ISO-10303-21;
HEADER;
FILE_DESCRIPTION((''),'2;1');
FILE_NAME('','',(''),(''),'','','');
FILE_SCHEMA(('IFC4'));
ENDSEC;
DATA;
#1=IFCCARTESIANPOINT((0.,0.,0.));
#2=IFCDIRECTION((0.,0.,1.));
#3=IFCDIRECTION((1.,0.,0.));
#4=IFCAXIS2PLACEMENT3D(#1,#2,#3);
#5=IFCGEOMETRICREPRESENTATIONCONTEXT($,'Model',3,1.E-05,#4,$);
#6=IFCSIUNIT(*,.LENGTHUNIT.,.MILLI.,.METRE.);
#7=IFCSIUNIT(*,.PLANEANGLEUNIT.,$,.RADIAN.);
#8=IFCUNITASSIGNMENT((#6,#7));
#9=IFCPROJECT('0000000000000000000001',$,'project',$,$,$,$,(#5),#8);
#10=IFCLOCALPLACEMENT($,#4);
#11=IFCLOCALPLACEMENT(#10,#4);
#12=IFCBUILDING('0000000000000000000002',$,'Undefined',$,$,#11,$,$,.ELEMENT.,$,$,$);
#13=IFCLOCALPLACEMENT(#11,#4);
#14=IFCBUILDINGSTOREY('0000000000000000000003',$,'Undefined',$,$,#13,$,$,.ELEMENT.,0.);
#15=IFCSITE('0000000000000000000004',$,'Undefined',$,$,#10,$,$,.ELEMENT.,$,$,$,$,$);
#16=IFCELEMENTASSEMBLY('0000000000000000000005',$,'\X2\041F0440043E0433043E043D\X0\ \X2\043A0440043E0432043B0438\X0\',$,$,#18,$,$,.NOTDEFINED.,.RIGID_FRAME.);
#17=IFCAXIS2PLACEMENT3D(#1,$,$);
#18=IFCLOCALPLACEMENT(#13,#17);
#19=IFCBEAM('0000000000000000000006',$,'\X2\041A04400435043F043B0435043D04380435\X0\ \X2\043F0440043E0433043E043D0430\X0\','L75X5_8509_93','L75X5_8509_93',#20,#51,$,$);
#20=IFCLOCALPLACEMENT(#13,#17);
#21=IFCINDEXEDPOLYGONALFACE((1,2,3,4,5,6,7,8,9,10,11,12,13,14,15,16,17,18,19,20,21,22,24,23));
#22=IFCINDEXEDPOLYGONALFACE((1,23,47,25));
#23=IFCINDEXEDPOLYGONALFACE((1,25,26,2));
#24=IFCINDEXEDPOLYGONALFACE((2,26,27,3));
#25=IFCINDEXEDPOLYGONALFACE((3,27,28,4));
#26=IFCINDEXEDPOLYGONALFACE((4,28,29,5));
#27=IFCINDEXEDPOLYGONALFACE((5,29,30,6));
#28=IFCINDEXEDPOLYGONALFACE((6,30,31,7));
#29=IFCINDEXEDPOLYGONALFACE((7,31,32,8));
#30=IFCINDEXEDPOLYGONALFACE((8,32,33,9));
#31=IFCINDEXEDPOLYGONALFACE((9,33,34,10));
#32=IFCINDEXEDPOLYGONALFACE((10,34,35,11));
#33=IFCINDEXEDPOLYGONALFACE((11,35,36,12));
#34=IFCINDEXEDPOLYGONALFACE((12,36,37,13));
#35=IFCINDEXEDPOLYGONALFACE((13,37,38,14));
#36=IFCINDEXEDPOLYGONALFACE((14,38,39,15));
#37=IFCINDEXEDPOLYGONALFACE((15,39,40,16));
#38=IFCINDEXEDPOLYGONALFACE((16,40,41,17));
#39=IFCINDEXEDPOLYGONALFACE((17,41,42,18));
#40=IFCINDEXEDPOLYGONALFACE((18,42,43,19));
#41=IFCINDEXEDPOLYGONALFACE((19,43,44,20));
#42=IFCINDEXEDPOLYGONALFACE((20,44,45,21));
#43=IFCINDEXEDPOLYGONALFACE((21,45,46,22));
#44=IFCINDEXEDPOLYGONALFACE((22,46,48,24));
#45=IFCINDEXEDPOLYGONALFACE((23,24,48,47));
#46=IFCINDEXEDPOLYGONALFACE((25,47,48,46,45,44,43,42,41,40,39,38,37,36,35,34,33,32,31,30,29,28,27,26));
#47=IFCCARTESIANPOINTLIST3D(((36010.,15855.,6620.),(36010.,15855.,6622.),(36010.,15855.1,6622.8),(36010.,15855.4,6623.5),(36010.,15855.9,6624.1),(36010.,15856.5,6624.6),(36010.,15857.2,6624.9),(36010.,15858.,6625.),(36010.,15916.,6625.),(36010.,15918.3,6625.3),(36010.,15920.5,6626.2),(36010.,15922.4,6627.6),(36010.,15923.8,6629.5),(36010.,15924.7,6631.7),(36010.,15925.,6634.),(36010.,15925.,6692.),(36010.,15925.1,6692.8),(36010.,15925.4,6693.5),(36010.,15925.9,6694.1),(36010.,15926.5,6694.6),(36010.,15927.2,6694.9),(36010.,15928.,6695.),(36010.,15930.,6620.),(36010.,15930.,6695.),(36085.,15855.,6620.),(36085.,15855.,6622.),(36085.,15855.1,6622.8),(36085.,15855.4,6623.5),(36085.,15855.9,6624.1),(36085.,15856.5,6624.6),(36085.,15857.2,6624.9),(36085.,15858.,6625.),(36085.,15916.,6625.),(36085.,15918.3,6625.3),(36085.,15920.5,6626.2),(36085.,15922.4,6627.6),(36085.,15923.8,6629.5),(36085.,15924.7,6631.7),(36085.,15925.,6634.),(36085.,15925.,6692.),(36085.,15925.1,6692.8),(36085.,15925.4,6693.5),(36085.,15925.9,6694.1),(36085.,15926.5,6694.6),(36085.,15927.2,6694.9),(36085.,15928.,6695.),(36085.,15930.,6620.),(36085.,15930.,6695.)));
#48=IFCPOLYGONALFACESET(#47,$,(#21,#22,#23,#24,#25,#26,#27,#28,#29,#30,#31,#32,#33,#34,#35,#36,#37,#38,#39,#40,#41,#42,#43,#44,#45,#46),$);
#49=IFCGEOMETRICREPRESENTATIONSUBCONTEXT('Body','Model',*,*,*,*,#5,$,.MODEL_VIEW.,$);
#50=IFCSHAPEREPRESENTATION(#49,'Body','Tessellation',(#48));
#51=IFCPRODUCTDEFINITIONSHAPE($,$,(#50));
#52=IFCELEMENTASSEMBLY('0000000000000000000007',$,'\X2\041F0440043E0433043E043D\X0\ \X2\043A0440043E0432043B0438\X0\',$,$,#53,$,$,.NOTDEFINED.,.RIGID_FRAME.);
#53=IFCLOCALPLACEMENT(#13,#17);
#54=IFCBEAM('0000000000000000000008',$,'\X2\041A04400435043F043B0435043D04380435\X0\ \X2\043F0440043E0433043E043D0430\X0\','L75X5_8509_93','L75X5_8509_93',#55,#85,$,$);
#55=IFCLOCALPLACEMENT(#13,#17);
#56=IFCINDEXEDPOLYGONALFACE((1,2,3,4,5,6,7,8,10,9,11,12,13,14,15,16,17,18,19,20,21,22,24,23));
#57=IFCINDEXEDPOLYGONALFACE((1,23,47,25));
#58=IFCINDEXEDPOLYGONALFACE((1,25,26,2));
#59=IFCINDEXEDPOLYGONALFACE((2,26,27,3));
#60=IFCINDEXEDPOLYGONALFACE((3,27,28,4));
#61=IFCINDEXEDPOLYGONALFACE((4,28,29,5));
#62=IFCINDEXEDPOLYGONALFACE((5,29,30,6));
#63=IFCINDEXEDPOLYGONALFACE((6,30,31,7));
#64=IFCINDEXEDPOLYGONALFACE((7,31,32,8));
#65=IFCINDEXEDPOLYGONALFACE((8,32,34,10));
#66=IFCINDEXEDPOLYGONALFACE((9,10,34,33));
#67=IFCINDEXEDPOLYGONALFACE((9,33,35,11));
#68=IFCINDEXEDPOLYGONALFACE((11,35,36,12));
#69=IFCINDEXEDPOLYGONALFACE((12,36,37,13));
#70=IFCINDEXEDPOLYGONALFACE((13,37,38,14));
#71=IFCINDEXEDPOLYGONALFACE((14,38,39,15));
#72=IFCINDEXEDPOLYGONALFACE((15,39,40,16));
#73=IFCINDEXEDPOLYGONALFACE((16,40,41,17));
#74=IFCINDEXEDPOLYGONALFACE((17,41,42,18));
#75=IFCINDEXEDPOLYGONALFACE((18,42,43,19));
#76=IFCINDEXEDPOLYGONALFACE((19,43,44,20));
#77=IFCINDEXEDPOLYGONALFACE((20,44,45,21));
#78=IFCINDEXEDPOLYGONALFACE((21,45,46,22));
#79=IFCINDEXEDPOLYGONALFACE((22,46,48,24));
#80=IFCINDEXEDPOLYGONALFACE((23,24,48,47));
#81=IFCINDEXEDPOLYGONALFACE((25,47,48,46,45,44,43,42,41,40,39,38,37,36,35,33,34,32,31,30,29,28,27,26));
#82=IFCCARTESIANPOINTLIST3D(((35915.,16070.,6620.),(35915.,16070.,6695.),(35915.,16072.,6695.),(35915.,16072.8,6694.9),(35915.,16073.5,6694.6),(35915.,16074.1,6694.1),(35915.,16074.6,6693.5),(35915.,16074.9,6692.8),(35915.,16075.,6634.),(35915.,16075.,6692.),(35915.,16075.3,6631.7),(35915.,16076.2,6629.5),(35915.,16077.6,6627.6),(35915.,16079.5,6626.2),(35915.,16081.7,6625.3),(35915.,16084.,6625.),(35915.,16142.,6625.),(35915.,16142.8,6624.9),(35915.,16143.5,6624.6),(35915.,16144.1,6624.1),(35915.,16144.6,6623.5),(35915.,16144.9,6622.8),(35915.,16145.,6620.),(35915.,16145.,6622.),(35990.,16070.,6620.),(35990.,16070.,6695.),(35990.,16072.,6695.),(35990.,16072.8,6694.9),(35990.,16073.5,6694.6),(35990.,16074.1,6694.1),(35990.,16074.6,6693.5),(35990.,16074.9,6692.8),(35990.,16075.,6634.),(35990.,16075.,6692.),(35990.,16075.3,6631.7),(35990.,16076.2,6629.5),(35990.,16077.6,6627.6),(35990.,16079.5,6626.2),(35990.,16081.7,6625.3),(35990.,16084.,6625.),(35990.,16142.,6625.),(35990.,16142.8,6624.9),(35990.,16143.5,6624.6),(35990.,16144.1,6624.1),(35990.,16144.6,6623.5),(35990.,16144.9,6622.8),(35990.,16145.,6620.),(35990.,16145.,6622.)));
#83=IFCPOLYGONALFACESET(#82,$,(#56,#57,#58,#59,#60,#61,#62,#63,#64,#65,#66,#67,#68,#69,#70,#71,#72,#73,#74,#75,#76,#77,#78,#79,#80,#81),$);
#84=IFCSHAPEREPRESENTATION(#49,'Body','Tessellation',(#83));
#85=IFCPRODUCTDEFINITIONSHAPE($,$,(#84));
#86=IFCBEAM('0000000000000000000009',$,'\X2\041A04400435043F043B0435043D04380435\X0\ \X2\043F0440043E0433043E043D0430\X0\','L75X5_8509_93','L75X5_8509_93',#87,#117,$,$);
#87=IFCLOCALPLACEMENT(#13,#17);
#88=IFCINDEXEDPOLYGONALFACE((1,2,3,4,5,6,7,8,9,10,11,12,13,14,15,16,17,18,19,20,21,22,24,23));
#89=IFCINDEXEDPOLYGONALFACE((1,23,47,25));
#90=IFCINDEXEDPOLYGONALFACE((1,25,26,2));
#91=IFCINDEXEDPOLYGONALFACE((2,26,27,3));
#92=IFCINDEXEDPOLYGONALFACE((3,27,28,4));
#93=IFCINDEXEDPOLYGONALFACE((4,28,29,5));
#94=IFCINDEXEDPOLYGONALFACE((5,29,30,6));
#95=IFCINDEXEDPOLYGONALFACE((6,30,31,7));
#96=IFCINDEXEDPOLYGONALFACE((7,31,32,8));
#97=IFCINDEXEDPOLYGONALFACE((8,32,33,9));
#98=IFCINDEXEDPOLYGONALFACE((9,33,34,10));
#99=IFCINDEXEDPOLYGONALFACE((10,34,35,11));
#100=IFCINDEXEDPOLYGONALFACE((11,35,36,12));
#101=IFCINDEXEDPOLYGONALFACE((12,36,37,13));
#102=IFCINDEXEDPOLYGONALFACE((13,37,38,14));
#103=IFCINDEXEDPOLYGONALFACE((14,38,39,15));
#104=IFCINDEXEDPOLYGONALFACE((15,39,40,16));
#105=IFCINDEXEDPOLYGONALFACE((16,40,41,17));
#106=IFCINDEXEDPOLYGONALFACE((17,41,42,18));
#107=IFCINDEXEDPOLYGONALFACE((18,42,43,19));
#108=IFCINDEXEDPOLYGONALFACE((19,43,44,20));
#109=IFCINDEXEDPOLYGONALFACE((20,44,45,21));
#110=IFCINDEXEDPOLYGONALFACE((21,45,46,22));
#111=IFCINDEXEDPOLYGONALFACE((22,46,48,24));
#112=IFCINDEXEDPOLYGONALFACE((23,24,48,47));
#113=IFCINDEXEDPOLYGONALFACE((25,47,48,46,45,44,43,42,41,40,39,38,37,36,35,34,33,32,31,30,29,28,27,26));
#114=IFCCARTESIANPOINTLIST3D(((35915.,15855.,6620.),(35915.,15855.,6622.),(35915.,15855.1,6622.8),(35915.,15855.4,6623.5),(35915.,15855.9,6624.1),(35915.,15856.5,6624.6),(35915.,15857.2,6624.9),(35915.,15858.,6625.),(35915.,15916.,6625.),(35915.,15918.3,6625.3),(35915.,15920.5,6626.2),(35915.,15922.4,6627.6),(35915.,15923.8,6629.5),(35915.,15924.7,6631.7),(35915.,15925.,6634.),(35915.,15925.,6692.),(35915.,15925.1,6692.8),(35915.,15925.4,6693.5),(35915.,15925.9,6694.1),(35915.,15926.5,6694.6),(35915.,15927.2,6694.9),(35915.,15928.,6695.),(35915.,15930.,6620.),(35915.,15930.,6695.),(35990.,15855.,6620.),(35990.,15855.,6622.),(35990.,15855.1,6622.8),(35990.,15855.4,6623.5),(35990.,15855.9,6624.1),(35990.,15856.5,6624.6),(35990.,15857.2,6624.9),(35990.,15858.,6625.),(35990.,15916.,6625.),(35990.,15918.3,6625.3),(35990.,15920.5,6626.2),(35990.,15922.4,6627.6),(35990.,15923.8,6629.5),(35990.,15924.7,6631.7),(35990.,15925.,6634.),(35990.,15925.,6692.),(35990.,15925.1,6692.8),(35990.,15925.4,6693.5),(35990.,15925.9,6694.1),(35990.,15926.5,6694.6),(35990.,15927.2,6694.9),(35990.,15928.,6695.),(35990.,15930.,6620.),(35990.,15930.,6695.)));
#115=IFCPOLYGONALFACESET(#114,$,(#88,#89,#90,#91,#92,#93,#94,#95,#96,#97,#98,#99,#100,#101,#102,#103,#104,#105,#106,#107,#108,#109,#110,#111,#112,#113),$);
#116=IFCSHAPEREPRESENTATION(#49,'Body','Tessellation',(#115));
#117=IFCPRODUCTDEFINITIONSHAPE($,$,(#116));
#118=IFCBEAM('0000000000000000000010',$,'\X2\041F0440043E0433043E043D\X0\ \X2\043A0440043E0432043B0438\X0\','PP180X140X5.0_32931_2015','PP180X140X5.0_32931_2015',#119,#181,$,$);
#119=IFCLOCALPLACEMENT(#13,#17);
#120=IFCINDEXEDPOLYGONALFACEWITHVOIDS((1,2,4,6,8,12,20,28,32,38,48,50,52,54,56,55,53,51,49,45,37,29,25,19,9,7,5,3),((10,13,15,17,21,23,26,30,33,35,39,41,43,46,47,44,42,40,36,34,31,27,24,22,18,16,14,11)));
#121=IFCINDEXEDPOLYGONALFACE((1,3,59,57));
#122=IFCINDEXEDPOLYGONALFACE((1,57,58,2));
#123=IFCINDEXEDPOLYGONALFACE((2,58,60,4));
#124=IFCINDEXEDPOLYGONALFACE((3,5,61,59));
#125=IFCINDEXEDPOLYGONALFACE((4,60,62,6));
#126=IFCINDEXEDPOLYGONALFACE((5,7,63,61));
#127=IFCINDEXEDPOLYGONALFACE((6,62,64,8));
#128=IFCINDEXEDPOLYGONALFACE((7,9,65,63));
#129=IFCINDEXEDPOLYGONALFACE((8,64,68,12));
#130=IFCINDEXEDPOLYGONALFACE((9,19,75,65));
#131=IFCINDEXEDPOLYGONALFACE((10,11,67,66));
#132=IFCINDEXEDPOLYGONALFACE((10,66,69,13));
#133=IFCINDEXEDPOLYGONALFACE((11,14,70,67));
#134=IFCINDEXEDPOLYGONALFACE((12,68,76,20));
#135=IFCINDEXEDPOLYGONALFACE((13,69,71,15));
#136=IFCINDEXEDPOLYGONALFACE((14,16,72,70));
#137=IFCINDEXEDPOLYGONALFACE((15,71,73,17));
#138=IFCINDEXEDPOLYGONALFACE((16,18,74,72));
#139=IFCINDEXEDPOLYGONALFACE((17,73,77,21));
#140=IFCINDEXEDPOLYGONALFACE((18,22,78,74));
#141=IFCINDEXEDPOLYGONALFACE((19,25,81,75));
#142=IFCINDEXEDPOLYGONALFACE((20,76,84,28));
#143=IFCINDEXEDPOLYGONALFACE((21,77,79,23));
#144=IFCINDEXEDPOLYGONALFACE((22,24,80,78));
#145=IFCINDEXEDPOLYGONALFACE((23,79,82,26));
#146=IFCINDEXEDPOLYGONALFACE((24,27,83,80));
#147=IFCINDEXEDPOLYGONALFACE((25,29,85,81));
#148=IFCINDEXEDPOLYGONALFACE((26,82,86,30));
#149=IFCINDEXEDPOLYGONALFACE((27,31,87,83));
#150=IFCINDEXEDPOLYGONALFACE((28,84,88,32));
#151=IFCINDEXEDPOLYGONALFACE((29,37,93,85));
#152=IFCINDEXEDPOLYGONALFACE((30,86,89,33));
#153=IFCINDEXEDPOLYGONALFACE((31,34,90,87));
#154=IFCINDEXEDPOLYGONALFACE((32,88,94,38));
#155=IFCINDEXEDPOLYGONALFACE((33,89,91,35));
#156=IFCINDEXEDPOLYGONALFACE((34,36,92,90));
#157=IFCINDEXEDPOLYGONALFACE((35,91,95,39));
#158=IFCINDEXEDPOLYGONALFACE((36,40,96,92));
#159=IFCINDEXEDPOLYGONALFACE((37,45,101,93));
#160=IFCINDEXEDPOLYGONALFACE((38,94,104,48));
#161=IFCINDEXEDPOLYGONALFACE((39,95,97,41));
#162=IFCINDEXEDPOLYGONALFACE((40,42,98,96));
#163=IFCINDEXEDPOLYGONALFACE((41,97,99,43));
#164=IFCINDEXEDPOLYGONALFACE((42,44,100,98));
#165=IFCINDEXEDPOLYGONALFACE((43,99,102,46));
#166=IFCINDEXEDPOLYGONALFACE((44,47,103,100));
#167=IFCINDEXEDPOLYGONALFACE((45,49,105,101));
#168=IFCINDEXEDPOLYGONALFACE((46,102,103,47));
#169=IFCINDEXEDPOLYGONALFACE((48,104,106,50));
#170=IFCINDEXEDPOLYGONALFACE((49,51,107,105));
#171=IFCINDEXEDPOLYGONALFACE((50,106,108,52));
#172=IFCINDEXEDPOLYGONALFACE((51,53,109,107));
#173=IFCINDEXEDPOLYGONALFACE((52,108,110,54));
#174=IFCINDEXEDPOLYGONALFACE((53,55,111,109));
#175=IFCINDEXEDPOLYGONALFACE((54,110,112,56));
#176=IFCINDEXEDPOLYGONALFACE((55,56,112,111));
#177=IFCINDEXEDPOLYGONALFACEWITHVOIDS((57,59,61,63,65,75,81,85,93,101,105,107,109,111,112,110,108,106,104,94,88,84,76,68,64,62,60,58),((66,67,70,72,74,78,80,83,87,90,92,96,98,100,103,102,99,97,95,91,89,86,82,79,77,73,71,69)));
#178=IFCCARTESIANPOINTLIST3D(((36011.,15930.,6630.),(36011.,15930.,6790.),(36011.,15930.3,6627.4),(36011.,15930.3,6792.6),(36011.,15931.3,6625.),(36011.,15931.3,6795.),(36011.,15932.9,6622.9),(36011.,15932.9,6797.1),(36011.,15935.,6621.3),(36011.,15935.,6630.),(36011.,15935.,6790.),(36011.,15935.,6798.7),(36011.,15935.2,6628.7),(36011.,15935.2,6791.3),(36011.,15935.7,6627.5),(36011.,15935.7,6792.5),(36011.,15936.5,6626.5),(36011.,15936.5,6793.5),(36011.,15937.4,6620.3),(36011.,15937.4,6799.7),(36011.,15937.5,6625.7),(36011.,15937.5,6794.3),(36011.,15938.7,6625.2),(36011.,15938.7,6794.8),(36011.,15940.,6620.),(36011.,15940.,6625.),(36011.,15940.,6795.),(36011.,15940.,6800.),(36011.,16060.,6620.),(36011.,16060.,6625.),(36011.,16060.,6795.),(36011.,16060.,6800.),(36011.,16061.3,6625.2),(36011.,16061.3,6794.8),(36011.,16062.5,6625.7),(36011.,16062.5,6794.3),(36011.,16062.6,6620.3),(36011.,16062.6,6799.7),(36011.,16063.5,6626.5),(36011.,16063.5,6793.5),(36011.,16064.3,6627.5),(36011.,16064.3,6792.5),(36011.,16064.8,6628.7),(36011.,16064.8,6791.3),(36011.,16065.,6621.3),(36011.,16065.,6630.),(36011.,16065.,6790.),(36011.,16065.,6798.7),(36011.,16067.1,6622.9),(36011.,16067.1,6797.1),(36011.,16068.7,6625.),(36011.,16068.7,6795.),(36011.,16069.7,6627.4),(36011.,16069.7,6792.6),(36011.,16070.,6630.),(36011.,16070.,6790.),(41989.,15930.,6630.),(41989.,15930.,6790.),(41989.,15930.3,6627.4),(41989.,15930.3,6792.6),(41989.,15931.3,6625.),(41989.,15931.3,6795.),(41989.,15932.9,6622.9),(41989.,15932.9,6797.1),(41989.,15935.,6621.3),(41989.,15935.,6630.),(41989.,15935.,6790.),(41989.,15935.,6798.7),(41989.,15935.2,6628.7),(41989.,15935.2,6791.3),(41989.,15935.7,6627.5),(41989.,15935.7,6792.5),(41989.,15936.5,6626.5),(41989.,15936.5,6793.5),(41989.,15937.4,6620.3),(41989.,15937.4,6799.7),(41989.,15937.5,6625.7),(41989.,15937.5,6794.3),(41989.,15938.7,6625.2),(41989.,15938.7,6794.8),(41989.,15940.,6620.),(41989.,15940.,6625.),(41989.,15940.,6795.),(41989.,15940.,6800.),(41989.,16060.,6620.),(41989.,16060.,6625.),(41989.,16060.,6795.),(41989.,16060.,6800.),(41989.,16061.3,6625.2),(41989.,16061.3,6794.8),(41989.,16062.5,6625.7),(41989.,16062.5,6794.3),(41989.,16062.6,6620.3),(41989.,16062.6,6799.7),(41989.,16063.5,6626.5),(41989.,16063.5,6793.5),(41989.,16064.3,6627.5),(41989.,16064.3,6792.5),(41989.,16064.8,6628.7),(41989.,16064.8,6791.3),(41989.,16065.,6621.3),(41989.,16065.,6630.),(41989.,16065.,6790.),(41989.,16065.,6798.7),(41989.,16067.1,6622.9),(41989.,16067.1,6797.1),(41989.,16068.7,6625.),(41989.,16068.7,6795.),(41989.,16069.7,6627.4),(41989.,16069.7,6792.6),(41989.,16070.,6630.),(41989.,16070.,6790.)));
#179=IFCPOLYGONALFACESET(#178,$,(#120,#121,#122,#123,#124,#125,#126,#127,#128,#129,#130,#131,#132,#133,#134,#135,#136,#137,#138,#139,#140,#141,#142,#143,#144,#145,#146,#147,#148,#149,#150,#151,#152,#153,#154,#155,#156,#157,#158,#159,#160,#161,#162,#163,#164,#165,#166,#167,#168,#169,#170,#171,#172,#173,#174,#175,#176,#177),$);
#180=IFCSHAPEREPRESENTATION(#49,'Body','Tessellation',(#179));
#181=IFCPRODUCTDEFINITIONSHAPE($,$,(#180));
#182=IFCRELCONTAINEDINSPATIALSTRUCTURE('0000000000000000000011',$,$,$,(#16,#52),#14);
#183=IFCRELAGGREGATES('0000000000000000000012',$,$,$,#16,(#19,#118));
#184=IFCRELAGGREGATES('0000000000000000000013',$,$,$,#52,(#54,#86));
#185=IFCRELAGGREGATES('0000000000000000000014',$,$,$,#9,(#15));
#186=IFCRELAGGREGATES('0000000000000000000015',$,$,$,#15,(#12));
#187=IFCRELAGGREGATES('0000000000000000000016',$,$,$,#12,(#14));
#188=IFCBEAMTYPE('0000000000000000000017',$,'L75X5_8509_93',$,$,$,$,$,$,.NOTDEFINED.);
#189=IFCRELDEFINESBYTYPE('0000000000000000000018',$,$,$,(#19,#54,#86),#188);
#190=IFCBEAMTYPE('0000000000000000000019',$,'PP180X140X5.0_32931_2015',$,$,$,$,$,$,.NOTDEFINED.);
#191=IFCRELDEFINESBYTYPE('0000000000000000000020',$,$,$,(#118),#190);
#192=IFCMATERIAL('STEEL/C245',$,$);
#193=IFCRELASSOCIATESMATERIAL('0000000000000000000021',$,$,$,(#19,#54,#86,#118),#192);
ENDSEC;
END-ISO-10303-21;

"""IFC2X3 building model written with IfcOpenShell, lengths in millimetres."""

from ifc_helpers import new_model, si_unit, frame, origin_with_axes, origin_2d_with_axis, place, context, subcontext, project, spatial, hollow_rectangle, l_section, extrude, clip, halfspace, material, type_object, element, aggregate, save


model = new_model("IFC2X3")

# Units and contexts
model_context = context("Model", 3, precision=1e-05, world=origin_with_axes())
body_context = subcontext(model_context, "Body", "Model", "MODEL_VIEW")
ifc_project = project(units=[si_unit("LENGTHUNIT", "METRE", prefix="MILLI"), si_unit("PLANEANGLEUNIT", "RADIAN")], contexts=[model_context])

# Site, building, storey
site_placement = place(None, origin_with_axes())
site = spatial("IfcSite", under=ifc_project, at=site_placement, Name="Undefined", CompositionType="ELEMENT")
building_placement = place(site_placement, origin_with_axes())
building = spatial("IfcBuilding", under=site, at=building_placement, Name="Undefined", CompositionType="ELEMENT")
storey_placement = place(building_placement, origin_with_axes())
storey = spatial("IfcBuildingStorey", under=building, at=storey_placement, Name="Undefined", CompositionType="ELEMENT", Elevation=0.0)

# Shared definitions
ifc_material_1 = material(Name="STEEL/C245")

# Element assemblies, beams
assembly_1_placement = place(storey_placement, origin_with_axes())
assembly_1 = element("IfcElementAssembly", 1, at=assembly_1_placement, inside=storey, Name="Прогон кровли", AssemblyPlace="NOTDEFINED", PredefinedType="RIGID_FRAME")
beam_type_1 = type_object("IfcBeamType", Name="L75X5_8509_93", PredefinedType="NOTDEFINED")
beam_1_placement = place(assembly_1_placement, frame((36085.0, 15892.5, 6657.5), z_axis=(0.0, -1.0, 0.0), x_axis=(-1.0, 0.0, 0.0)))
beam_1 = element("IfcBeam", 2, at=beam_1_placement, type_object=beam_type_1, material=ifc_material_1, Name="Крепление прогона", Description="L75X5_8509_93", ObjectType="L75X5_8509_93", context=body_context, shape_type="SweptSolid", body=[
    extrude(l_section(Depth=75.0, Width=75.0, Thickness=5.0, FilletRadius=9.0, EdgeRadius=3.0, at=origin_2d_with_axis()), frame((75.0, 0.0, 0.0), z_axis=(-1.0, 0.0, 0.0), x_axis=(0.0, -1.0, 0.0)), (0.0, 0.0, 1.0), 75.0),
])
assembly_2_placement = place(storey_placement, origin_with_axes())
assembly_2 = element("IfcElementAssembly", 3, at=assembly_2_placement, inside=storey, Name="Прогон кровли", AssemblyPlace="NOTDEFINED", PredefinedType="RIGID_FRAME")
beam_2_placement = place(assembly_2_placement, frame((35915.0, 16107.5, 6657.5), z_axis=(0.0, 1.0, 0.0), x_axis=(1.0, 0.0, 0.0)))
beam_2 = element("IfcBeam", 4, at=beam_2_placement, type_object=beam_type_1, material=ifc_material_1, Name="Крепление прогона", Description="L75X5_8509_93", ObjectType="L75X5_8509_93", context=body_context, shape_type="SweptSolid", body=[
    extrude(l_section(Depth=75.0, Width=75.0, Thickness=5.0, FilletRadius=9.0, EdgeRadius=3.0, at=origin_2d_with_axis()), frame((75.0, 0.0, 0.0), z_axis=(-1.0, 0.0, 0.0), x_axis=(0.0, -1.0, 0.0)), (0.0, 0.0, 1.0), 75.0),
])
beam_3_placement = place(assembly_2_placement, frame((35990.0, 15892.5, 6657.5), z_axis=(0.0, -1.0, 0.0), x_axis=(-1.0, 0.0, 0.0)))
beam_3 = element("IfcBeam", 5, at=beam_3_placement, type_object=beam_type_1, material=ifc_material_1, Name="Крепление прогона", Description="L75X5_8509_93", ObjectType="L75X5_8509_93", context=body_context, shape_type="SweptSolid", body=[
    extrude(l_section(Depth=75.0, Width=75.0, Thickness=5.0, FilletRadius=9.0, EdgeRadius=3.0, at=origin_2d_with_axis()), frame((75.0, 0.0, 0.0), z_axis=(-1.0, 0.0, 0.0), x_axis=(0.0, -1.0, 0.0)), (0.0, 0.0, 1.0), 75.0),
])

# Beam
beam_type_2 = type_object("IfcBeamType", Name="PP180X140X5.0_32931_2015", PredefinedType="NOTDEFINED")
beam_4_placement = place(assembly_1_placement, frame((36005.0, 16000.0, 6710.0), z_axis=(0.0, 0.0, 1.0), x_axis=(1.0, 0.0, 0.0)))
beam_4 = element("IfcBeam", 6, at=beam_4_placement, type_object=beam_type_2, material=ifc_material_1, Name="Прогон кровли", Description="PP180X140X5.0_32931_2015", ObjectType="PP180X140X5.0_32931_2015", context=body_context, shape_type="Clipping", body=[
    clip(clip(extrude(hollow_rectangle(XDim=140.0, YDim=180.0, WallThickness=5.0, InnerFilletRadius=5.0, OuterFilletRadius=10.0, at=origin_2d_with_axis()), frame((5984.0, 0.0, 0.0), z_axis=(-1.0, 0.0, 0.0), x_axis=(0.0, -1.0, 0.0)), (0.0, 0.0, 1.0), 5978.0), halfspace(frame((5984.0, 0.0, -90.0), z_axis=(-1.0, 0.0, 0.0), x_axis=(0.0, 1.0, 0.0)), True)), halfspace(frame((6.0, 0.0, -90.0), z_axis=(1.0, 0.0, 0.0), x_axis=(0.0, -1.0, 0.0)), True)),
])

aggregate(assembly_1, [beam_1, beam_4])
aggregate(assembly_2, [beam_2, beam_3])

save(model, "model.ifc")
